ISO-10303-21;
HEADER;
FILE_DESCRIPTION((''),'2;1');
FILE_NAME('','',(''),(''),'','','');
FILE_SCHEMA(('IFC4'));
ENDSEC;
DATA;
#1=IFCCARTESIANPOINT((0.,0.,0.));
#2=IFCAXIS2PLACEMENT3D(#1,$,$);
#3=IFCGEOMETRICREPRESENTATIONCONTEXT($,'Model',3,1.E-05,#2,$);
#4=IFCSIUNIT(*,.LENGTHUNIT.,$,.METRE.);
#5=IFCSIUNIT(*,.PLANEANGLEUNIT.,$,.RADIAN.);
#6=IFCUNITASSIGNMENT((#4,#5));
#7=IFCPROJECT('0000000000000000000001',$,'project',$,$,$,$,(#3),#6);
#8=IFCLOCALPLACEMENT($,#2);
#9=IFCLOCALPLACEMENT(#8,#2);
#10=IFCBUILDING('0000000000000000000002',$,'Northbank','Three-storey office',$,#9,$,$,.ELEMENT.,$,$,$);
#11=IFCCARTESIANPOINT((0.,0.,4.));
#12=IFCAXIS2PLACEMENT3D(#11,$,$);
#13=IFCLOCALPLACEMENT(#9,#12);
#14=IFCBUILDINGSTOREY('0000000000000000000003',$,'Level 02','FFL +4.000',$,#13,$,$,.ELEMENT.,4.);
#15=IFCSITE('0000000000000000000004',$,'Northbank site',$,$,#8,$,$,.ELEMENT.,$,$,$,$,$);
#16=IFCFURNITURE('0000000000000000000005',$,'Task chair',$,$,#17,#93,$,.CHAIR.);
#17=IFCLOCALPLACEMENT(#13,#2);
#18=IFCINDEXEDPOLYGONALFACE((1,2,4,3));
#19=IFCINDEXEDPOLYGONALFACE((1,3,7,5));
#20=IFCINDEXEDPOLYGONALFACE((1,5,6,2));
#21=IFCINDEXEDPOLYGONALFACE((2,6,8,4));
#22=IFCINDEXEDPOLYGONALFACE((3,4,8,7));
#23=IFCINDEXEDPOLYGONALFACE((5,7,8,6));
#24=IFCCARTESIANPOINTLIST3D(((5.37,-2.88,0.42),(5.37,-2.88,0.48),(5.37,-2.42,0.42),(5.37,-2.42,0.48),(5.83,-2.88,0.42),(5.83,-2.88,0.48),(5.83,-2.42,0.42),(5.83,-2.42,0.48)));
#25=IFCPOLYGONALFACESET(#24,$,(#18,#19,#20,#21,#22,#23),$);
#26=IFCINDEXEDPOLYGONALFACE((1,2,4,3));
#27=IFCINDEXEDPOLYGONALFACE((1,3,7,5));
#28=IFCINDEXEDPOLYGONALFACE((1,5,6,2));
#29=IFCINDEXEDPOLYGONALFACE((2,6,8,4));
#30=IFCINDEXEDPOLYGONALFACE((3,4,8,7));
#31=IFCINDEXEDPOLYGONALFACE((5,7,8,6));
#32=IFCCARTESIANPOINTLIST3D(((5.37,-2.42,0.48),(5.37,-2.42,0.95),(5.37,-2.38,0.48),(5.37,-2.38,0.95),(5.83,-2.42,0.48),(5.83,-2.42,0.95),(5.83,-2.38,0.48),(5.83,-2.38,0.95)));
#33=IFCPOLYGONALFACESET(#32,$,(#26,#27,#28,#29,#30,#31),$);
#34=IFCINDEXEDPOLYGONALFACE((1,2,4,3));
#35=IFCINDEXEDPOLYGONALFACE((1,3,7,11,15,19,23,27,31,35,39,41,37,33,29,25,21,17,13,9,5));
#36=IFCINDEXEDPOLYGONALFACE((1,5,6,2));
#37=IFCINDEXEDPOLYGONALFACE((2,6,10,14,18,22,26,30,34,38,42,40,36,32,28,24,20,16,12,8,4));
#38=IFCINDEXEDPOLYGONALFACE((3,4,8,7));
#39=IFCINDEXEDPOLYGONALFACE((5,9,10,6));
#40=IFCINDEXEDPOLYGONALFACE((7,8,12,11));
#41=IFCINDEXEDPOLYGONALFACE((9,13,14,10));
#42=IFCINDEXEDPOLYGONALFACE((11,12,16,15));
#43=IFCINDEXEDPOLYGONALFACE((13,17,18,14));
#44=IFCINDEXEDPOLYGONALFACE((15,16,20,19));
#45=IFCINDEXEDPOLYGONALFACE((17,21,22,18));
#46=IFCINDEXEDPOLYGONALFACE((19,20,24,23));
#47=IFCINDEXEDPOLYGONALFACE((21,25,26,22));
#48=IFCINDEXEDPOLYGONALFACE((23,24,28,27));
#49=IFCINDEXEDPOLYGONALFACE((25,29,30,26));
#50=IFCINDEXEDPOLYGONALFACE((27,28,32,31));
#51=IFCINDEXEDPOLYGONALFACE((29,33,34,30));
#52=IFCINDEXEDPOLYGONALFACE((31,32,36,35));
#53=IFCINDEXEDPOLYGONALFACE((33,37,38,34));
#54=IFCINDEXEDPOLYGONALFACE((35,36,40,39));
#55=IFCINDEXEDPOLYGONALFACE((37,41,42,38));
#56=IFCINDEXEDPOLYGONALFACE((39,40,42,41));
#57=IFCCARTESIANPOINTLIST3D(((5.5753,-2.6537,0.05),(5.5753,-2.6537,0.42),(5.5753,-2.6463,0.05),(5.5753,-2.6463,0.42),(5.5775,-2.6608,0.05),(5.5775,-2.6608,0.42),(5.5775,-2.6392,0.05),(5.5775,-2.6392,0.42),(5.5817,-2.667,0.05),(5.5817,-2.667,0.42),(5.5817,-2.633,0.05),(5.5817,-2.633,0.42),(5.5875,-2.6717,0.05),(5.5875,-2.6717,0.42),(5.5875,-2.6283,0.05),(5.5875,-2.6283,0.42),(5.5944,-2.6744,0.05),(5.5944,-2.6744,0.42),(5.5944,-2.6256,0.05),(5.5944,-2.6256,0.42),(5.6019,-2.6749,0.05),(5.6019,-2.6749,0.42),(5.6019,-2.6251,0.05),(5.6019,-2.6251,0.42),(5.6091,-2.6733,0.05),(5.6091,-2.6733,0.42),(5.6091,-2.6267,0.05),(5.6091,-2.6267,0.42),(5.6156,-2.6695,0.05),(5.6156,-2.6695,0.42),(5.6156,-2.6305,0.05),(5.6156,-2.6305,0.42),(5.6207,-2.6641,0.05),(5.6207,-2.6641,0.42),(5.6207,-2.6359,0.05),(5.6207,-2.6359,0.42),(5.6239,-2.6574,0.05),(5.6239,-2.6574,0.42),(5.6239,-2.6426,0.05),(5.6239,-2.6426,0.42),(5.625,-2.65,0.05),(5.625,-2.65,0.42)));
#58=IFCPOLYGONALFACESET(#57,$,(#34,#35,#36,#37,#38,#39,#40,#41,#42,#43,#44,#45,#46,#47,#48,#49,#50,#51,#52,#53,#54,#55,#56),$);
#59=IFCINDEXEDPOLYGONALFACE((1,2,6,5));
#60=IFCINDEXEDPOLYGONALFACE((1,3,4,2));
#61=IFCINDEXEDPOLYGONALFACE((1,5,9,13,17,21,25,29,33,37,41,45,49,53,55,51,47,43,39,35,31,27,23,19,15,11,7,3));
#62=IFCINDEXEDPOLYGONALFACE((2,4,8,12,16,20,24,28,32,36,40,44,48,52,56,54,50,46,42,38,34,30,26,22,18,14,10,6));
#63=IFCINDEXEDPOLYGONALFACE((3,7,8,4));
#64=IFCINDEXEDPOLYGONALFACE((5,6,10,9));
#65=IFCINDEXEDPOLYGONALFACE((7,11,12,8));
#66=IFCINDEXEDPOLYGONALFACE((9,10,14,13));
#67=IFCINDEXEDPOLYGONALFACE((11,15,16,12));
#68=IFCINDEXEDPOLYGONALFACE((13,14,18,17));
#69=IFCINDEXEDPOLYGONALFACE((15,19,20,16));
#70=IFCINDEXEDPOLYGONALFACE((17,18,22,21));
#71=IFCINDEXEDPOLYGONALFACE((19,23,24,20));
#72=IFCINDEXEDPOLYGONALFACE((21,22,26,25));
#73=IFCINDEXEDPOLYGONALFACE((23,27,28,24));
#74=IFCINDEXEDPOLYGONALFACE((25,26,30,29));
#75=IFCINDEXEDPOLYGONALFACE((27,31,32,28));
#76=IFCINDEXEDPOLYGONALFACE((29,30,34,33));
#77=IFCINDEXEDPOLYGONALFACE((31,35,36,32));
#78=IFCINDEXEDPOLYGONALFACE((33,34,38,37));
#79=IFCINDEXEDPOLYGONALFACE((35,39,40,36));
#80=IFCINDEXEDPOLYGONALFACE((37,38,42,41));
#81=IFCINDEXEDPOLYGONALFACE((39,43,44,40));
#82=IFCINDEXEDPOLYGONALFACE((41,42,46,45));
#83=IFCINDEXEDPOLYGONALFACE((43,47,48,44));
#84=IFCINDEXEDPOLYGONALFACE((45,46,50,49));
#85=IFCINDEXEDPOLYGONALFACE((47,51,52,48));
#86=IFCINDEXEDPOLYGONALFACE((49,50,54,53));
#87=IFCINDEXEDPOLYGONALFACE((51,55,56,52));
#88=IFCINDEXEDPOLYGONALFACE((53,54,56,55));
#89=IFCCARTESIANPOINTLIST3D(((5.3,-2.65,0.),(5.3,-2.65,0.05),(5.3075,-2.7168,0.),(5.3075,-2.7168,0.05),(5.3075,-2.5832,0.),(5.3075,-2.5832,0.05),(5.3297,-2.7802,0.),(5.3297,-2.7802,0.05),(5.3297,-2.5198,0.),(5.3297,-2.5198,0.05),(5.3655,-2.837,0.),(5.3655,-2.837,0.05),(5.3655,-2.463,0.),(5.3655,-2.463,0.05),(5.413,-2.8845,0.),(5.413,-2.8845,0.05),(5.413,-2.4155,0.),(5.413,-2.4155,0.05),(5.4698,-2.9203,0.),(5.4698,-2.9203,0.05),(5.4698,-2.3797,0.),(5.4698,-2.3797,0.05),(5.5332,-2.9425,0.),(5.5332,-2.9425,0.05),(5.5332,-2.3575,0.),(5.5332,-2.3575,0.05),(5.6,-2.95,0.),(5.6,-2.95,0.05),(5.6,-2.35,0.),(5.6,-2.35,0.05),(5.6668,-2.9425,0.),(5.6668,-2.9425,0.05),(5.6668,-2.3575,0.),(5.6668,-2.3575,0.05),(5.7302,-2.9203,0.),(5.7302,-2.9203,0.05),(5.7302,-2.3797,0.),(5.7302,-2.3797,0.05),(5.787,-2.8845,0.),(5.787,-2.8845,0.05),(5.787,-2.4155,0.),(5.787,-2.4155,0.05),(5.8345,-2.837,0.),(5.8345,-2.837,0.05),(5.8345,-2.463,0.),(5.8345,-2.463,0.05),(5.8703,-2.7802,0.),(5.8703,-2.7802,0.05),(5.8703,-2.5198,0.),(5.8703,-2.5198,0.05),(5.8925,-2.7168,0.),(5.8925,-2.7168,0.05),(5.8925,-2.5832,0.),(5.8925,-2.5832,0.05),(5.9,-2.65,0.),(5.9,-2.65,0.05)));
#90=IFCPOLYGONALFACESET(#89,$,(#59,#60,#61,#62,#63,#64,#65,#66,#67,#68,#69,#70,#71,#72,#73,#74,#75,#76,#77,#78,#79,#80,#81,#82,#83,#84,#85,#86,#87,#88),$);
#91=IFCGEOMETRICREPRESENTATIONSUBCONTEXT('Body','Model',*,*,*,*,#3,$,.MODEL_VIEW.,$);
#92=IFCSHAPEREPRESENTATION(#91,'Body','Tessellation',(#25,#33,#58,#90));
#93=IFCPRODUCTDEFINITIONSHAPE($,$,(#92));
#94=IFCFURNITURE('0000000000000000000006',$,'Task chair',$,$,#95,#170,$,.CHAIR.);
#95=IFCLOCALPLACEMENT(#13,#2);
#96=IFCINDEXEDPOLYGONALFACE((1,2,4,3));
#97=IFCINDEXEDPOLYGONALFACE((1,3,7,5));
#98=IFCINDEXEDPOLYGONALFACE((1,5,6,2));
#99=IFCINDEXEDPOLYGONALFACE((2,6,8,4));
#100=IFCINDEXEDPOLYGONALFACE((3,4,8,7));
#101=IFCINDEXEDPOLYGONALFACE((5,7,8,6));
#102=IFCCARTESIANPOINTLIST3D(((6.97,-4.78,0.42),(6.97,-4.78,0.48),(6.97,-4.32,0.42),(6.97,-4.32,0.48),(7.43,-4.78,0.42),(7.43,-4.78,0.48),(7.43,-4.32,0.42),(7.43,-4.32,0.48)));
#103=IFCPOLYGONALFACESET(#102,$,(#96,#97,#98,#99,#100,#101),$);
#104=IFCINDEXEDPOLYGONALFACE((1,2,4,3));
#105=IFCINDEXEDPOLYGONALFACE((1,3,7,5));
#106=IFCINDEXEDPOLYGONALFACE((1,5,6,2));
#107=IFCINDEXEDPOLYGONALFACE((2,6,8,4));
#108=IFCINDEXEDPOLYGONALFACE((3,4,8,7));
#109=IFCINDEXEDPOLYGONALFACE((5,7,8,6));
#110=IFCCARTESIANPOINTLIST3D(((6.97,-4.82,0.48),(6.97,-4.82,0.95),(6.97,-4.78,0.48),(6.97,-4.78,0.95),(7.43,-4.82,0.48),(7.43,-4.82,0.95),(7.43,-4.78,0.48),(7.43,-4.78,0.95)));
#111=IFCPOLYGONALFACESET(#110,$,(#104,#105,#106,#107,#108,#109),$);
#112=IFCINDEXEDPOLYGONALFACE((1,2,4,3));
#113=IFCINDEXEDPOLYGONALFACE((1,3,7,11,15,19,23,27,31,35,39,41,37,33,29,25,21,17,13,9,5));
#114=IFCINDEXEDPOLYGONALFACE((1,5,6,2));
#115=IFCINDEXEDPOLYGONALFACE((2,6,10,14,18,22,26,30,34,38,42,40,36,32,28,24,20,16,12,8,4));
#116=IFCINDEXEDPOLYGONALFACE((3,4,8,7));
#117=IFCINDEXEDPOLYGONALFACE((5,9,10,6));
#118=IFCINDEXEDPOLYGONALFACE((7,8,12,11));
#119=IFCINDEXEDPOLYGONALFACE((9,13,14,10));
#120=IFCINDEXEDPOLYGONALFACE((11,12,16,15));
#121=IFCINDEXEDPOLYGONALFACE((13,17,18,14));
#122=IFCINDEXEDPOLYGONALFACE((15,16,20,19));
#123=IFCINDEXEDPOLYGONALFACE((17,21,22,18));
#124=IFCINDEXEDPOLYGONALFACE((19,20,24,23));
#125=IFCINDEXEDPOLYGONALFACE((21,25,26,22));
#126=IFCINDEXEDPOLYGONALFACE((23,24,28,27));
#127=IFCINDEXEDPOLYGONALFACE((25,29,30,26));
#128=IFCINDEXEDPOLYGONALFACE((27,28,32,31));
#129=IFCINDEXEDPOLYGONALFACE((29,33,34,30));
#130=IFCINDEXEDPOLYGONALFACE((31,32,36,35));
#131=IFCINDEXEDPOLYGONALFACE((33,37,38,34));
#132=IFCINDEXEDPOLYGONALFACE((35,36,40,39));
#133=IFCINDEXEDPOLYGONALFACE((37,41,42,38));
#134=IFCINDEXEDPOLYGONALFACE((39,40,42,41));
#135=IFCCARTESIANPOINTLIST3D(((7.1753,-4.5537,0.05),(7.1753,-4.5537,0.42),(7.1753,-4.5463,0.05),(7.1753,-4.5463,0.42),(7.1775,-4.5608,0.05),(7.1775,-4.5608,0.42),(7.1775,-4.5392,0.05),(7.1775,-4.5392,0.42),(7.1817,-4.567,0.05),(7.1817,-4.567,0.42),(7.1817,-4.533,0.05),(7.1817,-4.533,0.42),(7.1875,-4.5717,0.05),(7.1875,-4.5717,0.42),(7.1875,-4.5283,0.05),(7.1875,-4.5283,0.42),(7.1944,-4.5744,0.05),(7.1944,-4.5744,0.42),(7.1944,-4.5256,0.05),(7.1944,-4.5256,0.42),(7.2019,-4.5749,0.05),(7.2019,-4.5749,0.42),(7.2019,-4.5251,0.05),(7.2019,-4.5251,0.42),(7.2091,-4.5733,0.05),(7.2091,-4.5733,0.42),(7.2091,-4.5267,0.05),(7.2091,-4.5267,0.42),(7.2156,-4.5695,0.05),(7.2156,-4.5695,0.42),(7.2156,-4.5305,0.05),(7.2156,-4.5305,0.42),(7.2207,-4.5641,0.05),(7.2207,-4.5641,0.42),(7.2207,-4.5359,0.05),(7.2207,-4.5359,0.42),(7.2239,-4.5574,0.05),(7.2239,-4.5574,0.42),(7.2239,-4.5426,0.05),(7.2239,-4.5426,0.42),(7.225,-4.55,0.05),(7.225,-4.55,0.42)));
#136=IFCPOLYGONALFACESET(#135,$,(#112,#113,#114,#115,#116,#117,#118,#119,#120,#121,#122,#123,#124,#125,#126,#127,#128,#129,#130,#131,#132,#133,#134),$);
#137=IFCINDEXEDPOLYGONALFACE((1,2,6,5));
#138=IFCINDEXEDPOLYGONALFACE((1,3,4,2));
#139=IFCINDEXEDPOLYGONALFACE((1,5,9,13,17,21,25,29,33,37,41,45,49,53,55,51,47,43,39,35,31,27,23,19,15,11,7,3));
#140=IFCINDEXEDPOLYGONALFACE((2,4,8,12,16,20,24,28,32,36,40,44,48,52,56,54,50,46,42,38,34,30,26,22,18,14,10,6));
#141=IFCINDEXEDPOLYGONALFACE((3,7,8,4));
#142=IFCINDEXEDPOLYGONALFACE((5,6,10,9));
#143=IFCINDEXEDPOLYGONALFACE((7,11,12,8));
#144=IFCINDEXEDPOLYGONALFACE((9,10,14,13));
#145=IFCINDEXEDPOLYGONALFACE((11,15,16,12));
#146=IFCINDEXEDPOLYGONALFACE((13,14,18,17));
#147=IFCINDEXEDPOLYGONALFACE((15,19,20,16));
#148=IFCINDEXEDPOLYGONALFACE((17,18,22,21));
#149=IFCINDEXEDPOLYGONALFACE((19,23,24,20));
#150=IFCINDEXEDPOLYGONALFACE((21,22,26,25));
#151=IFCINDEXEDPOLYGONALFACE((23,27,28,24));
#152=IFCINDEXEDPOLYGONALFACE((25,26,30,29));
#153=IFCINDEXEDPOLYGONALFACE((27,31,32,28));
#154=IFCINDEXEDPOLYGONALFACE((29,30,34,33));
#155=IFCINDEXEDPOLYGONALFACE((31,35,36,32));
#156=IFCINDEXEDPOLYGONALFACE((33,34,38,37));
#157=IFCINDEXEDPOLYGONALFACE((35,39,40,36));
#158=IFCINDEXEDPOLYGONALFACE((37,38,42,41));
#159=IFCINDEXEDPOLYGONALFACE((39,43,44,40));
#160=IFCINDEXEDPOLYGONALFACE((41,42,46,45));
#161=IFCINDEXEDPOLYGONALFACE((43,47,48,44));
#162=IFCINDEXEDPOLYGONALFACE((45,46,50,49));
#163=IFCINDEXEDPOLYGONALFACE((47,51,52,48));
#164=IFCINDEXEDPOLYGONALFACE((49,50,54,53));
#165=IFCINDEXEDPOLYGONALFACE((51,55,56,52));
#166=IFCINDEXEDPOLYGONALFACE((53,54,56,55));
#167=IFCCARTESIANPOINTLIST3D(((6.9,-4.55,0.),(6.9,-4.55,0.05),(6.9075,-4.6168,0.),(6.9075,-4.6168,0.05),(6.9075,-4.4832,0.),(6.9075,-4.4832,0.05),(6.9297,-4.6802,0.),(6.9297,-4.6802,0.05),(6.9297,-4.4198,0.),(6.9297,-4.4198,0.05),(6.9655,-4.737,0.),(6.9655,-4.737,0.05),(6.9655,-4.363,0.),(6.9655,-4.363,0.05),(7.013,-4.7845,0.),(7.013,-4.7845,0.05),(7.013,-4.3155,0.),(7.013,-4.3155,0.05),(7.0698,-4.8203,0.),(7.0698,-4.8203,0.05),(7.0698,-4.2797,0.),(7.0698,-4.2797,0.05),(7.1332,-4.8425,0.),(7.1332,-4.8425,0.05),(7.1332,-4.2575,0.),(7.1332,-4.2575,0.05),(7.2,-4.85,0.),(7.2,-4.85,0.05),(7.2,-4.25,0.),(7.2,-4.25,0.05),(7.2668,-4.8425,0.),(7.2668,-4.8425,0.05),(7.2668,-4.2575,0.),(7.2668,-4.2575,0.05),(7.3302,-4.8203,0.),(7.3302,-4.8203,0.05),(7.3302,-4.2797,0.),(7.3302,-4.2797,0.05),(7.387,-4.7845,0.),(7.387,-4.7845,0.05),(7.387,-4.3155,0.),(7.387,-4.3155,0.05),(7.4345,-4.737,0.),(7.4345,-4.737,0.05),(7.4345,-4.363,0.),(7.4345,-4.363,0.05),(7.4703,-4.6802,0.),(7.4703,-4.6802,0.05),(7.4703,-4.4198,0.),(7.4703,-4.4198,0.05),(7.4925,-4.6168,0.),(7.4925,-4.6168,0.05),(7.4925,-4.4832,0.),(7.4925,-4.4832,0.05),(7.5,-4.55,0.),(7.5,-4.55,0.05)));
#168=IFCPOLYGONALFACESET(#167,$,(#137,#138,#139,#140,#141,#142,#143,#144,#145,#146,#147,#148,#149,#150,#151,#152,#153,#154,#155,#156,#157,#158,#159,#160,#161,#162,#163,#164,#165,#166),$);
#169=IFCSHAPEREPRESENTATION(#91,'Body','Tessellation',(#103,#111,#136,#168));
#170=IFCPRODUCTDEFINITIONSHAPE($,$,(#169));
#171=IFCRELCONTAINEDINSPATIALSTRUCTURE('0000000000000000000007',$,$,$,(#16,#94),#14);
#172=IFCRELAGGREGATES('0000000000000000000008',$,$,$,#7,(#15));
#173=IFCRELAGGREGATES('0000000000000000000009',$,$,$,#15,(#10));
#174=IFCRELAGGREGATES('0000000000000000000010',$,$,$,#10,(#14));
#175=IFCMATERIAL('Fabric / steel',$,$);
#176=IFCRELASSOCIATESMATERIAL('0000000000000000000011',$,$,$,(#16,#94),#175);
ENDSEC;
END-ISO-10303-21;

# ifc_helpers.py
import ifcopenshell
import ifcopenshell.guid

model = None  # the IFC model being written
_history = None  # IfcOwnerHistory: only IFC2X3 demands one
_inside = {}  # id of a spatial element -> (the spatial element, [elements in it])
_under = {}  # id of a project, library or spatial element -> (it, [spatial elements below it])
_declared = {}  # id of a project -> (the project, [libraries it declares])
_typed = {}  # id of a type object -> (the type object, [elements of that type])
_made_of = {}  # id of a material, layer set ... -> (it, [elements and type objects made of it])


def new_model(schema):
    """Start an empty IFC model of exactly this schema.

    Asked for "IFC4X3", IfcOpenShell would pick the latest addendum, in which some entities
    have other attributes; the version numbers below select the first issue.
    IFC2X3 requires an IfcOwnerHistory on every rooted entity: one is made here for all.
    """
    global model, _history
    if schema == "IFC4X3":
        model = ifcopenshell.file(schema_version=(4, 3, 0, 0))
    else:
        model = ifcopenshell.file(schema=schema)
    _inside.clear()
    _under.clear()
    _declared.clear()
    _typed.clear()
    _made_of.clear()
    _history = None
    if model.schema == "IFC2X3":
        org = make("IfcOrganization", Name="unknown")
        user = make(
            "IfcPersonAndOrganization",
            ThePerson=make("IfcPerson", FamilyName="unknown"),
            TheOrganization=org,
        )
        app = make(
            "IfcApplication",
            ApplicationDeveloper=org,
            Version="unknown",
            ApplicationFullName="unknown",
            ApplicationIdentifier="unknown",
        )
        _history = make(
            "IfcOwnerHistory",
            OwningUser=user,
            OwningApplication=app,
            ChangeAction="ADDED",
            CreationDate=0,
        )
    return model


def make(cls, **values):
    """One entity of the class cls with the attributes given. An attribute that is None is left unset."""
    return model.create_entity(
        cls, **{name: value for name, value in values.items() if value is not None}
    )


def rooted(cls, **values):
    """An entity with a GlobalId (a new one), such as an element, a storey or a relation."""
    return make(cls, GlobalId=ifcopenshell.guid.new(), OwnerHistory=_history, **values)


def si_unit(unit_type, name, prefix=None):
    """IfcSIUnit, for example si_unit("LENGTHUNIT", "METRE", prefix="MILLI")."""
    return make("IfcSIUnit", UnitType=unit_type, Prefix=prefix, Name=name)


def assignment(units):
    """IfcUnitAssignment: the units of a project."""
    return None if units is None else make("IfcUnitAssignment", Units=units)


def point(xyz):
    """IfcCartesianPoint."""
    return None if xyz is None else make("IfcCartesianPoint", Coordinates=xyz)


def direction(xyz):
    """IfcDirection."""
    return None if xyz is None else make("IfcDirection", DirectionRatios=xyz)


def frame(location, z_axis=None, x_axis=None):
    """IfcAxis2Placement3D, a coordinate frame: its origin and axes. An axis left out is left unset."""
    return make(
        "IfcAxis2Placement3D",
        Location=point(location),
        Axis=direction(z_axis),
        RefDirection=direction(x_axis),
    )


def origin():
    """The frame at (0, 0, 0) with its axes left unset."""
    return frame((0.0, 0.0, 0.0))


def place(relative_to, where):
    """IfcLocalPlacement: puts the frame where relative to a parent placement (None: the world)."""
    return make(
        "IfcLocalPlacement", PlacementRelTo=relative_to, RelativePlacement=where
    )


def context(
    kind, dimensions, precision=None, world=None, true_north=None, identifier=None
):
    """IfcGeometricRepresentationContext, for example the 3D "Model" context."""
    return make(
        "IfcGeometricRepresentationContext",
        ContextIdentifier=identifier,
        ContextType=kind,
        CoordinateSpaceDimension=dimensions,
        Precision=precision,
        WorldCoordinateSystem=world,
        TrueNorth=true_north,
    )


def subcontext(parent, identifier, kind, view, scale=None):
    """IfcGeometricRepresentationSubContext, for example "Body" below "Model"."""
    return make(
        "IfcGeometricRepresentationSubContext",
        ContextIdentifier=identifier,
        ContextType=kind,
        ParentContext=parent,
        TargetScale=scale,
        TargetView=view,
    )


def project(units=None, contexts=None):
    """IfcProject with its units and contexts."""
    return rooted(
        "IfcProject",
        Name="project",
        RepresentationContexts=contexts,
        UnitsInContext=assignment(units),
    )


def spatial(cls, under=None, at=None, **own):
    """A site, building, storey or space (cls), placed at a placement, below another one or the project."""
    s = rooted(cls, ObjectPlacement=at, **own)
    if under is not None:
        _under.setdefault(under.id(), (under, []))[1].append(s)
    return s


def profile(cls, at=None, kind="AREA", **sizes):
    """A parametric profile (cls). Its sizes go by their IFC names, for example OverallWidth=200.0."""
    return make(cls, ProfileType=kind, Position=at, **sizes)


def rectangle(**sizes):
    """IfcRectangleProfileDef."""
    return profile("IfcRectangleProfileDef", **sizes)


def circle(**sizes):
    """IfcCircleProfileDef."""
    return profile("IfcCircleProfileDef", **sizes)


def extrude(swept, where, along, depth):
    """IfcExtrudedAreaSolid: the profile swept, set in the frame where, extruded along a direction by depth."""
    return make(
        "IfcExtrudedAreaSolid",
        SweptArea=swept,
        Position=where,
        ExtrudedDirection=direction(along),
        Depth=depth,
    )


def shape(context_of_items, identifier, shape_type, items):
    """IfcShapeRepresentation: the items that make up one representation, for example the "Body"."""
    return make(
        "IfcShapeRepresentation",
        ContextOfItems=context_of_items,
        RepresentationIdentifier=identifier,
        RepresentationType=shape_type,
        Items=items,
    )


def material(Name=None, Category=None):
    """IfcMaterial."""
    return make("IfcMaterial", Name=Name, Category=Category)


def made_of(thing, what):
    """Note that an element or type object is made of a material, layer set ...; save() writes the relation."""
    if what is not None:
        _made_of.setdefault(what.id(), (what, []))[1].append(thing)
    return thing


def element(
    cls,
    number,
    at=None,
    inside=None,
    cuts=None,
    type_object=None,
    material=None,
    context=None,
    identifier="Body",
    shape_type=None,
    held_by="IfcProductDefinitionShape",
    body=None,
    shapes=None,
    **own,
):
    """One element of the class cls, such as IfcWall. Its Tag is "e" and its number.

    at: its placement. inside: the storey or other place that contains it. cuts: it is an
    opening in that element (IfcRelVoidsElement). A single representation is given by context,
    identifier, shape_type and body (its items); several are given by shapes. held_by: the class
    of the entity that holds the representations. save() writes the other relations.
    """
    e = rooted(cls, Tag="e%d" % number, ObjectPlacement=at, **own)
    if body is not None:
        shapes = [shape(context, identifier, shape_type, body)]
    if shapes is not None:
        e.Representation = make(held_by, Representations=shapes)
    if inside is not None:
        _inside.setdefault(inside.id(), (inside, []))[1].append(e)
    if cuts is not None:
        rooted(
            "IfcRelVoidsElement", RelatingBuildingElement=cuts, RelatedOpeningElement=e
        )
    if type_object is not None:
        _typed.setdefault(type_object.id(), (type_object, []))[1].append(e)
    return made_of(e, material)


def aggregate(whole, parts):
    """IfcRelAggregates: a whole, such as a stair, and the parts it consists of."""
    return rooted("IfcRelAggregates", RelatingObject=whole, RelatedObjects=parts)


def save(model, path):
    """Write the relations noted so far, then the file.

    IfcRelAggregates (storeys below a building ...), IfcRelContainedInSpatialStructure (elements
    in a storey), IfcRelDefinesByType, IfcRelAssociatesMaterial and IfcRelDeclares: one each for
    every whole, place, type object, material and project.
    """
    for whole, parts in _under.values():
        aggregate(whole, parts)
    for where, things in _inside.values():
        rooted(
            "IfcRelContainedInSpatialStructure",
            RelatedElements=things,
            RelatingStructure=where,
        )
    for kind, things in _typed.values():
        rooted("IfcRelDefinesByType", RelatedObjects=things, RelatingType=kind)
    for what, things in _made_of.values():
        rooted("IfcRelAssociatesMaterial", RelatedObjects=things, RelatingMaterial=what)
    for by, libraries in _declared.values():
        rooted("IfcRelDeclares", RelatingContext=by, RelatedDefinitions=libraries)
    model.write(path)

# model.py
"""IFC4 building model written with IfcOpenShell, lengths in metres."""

from ifc_helpers import new_model, si_unit, frame, origin, place, context, subcontext, project, spatial, rectangle, circle, extrude, material, element, save


model = new_model("IFC4")

# Units and contexts
model_context = context("Model", 3, precision=1e-05, world=origin())
body_context = subcontext(model_context, "Body", "Model", "MODEL_VIEW")
ifc_project = project(units=[si_unit("LENGTHUNIT", "METRE"), si_unit("PLANEANGLEUNIT", "RADIAN")], contexts=[model_context])

# Site, building, storey
site_placement = place(None, origin())
site = spatial("IfcSite", under=ifc_project, at=site_placement, Name="Northbank site", CompositionType="ELEMENT")
building_placement = place(site_placement, origin())
building = spatial("IfcBuilding", under=site, at=building_placement, Name="Northbank", Description="Three-storey office", CompositionType="ELEMENT")
storey_placement = place(building_placement, frame((0.0, 0.0, 4.0)))
storey = spatial("IfcBuildingStorey", under=building, at=storey_placement, Name="Level 02", Description="FFL +4.000", CompositionType="ELEMENT", Elevation=4.0)

# Furniture
ifc_material_1 = material(Name="Fabric / steel")
furniture_1_placement = place(storey_placement, frame((0.0, 0.0, -4.0)))
element("IfcFurniture", 1, at=furniture_1_placement, inside=storey, material=ifc_material_1, Name="Task chair", PredefinedType="CHAIR", context=body_context, shape_type="SweptSolid", body=[
    extrude(rectangle(XDim=0.46, YDim=0.46), frame((5.6, -2.65, 4.42)), (0.0, 0.0, 1.0), 0.06),
    extrude(rectangle(XDim=0.46, YDim=0.04), frame((5.6, -2.4, 4.48)), (0.0, 0.0, 1.0), 0.47),
    extrude(circle(Radius=0.025), frame((5.6, -2.65, 4.05), z_axis=(0.0, 0.0, 1.0), x_axis=(1.0, 0.0, 0.0)), (0.0, 0.0, 1.0), 0.37),
    extrude(circle(Radius=0.3), frame((5.6, -2.65, 4.0), z_axis=(0.0, 0.0, 1.0), x_axis=(1.0, 0.0, 0.0)), (0.0, 0.0, 1.0), 0.05),
])
furniture_2_placement = place(storey_placement, frame((0.0, 0.0, -4.0)))
element("IfcFurniture", 2, at=furniture_2_placement, inside=storey, material=ifc_material_1, Name="Task chair", PredefinedType="CHAIR", context=body_context, shape_type="SweptSolid", body=[
    extrude(rectangle(XDim=0.46, YDim=0.46), frame((7.2, -4.55, 4.42)), (0.0, 0.0, 1.0), 0.06),
    extrude(rectangle(XDim=0.46, YDim=0.04), frame((7.2, -4.8, 4.48)), (0.0, 0.0, 1.0), 0.47),
    extrude(circle(Radius=0.025), frame((7.2, -4.55, 4.05), z_axis=(0.0, 0.0, 1.0), x_axis=(1.0, 0.0, 0.0)), (0.0, 0.0, 1.0), 0.37),
    extrude(circle(Radius=0.3), frame((7.2, -4.55, 4.0), z_axis=(0.0, 0.0, 1.0), x_axis=(1.0, 0.0, 0.0)), (0.0, 0.0, 1.0), 0.05),
])

save(model, "model.ifc")
